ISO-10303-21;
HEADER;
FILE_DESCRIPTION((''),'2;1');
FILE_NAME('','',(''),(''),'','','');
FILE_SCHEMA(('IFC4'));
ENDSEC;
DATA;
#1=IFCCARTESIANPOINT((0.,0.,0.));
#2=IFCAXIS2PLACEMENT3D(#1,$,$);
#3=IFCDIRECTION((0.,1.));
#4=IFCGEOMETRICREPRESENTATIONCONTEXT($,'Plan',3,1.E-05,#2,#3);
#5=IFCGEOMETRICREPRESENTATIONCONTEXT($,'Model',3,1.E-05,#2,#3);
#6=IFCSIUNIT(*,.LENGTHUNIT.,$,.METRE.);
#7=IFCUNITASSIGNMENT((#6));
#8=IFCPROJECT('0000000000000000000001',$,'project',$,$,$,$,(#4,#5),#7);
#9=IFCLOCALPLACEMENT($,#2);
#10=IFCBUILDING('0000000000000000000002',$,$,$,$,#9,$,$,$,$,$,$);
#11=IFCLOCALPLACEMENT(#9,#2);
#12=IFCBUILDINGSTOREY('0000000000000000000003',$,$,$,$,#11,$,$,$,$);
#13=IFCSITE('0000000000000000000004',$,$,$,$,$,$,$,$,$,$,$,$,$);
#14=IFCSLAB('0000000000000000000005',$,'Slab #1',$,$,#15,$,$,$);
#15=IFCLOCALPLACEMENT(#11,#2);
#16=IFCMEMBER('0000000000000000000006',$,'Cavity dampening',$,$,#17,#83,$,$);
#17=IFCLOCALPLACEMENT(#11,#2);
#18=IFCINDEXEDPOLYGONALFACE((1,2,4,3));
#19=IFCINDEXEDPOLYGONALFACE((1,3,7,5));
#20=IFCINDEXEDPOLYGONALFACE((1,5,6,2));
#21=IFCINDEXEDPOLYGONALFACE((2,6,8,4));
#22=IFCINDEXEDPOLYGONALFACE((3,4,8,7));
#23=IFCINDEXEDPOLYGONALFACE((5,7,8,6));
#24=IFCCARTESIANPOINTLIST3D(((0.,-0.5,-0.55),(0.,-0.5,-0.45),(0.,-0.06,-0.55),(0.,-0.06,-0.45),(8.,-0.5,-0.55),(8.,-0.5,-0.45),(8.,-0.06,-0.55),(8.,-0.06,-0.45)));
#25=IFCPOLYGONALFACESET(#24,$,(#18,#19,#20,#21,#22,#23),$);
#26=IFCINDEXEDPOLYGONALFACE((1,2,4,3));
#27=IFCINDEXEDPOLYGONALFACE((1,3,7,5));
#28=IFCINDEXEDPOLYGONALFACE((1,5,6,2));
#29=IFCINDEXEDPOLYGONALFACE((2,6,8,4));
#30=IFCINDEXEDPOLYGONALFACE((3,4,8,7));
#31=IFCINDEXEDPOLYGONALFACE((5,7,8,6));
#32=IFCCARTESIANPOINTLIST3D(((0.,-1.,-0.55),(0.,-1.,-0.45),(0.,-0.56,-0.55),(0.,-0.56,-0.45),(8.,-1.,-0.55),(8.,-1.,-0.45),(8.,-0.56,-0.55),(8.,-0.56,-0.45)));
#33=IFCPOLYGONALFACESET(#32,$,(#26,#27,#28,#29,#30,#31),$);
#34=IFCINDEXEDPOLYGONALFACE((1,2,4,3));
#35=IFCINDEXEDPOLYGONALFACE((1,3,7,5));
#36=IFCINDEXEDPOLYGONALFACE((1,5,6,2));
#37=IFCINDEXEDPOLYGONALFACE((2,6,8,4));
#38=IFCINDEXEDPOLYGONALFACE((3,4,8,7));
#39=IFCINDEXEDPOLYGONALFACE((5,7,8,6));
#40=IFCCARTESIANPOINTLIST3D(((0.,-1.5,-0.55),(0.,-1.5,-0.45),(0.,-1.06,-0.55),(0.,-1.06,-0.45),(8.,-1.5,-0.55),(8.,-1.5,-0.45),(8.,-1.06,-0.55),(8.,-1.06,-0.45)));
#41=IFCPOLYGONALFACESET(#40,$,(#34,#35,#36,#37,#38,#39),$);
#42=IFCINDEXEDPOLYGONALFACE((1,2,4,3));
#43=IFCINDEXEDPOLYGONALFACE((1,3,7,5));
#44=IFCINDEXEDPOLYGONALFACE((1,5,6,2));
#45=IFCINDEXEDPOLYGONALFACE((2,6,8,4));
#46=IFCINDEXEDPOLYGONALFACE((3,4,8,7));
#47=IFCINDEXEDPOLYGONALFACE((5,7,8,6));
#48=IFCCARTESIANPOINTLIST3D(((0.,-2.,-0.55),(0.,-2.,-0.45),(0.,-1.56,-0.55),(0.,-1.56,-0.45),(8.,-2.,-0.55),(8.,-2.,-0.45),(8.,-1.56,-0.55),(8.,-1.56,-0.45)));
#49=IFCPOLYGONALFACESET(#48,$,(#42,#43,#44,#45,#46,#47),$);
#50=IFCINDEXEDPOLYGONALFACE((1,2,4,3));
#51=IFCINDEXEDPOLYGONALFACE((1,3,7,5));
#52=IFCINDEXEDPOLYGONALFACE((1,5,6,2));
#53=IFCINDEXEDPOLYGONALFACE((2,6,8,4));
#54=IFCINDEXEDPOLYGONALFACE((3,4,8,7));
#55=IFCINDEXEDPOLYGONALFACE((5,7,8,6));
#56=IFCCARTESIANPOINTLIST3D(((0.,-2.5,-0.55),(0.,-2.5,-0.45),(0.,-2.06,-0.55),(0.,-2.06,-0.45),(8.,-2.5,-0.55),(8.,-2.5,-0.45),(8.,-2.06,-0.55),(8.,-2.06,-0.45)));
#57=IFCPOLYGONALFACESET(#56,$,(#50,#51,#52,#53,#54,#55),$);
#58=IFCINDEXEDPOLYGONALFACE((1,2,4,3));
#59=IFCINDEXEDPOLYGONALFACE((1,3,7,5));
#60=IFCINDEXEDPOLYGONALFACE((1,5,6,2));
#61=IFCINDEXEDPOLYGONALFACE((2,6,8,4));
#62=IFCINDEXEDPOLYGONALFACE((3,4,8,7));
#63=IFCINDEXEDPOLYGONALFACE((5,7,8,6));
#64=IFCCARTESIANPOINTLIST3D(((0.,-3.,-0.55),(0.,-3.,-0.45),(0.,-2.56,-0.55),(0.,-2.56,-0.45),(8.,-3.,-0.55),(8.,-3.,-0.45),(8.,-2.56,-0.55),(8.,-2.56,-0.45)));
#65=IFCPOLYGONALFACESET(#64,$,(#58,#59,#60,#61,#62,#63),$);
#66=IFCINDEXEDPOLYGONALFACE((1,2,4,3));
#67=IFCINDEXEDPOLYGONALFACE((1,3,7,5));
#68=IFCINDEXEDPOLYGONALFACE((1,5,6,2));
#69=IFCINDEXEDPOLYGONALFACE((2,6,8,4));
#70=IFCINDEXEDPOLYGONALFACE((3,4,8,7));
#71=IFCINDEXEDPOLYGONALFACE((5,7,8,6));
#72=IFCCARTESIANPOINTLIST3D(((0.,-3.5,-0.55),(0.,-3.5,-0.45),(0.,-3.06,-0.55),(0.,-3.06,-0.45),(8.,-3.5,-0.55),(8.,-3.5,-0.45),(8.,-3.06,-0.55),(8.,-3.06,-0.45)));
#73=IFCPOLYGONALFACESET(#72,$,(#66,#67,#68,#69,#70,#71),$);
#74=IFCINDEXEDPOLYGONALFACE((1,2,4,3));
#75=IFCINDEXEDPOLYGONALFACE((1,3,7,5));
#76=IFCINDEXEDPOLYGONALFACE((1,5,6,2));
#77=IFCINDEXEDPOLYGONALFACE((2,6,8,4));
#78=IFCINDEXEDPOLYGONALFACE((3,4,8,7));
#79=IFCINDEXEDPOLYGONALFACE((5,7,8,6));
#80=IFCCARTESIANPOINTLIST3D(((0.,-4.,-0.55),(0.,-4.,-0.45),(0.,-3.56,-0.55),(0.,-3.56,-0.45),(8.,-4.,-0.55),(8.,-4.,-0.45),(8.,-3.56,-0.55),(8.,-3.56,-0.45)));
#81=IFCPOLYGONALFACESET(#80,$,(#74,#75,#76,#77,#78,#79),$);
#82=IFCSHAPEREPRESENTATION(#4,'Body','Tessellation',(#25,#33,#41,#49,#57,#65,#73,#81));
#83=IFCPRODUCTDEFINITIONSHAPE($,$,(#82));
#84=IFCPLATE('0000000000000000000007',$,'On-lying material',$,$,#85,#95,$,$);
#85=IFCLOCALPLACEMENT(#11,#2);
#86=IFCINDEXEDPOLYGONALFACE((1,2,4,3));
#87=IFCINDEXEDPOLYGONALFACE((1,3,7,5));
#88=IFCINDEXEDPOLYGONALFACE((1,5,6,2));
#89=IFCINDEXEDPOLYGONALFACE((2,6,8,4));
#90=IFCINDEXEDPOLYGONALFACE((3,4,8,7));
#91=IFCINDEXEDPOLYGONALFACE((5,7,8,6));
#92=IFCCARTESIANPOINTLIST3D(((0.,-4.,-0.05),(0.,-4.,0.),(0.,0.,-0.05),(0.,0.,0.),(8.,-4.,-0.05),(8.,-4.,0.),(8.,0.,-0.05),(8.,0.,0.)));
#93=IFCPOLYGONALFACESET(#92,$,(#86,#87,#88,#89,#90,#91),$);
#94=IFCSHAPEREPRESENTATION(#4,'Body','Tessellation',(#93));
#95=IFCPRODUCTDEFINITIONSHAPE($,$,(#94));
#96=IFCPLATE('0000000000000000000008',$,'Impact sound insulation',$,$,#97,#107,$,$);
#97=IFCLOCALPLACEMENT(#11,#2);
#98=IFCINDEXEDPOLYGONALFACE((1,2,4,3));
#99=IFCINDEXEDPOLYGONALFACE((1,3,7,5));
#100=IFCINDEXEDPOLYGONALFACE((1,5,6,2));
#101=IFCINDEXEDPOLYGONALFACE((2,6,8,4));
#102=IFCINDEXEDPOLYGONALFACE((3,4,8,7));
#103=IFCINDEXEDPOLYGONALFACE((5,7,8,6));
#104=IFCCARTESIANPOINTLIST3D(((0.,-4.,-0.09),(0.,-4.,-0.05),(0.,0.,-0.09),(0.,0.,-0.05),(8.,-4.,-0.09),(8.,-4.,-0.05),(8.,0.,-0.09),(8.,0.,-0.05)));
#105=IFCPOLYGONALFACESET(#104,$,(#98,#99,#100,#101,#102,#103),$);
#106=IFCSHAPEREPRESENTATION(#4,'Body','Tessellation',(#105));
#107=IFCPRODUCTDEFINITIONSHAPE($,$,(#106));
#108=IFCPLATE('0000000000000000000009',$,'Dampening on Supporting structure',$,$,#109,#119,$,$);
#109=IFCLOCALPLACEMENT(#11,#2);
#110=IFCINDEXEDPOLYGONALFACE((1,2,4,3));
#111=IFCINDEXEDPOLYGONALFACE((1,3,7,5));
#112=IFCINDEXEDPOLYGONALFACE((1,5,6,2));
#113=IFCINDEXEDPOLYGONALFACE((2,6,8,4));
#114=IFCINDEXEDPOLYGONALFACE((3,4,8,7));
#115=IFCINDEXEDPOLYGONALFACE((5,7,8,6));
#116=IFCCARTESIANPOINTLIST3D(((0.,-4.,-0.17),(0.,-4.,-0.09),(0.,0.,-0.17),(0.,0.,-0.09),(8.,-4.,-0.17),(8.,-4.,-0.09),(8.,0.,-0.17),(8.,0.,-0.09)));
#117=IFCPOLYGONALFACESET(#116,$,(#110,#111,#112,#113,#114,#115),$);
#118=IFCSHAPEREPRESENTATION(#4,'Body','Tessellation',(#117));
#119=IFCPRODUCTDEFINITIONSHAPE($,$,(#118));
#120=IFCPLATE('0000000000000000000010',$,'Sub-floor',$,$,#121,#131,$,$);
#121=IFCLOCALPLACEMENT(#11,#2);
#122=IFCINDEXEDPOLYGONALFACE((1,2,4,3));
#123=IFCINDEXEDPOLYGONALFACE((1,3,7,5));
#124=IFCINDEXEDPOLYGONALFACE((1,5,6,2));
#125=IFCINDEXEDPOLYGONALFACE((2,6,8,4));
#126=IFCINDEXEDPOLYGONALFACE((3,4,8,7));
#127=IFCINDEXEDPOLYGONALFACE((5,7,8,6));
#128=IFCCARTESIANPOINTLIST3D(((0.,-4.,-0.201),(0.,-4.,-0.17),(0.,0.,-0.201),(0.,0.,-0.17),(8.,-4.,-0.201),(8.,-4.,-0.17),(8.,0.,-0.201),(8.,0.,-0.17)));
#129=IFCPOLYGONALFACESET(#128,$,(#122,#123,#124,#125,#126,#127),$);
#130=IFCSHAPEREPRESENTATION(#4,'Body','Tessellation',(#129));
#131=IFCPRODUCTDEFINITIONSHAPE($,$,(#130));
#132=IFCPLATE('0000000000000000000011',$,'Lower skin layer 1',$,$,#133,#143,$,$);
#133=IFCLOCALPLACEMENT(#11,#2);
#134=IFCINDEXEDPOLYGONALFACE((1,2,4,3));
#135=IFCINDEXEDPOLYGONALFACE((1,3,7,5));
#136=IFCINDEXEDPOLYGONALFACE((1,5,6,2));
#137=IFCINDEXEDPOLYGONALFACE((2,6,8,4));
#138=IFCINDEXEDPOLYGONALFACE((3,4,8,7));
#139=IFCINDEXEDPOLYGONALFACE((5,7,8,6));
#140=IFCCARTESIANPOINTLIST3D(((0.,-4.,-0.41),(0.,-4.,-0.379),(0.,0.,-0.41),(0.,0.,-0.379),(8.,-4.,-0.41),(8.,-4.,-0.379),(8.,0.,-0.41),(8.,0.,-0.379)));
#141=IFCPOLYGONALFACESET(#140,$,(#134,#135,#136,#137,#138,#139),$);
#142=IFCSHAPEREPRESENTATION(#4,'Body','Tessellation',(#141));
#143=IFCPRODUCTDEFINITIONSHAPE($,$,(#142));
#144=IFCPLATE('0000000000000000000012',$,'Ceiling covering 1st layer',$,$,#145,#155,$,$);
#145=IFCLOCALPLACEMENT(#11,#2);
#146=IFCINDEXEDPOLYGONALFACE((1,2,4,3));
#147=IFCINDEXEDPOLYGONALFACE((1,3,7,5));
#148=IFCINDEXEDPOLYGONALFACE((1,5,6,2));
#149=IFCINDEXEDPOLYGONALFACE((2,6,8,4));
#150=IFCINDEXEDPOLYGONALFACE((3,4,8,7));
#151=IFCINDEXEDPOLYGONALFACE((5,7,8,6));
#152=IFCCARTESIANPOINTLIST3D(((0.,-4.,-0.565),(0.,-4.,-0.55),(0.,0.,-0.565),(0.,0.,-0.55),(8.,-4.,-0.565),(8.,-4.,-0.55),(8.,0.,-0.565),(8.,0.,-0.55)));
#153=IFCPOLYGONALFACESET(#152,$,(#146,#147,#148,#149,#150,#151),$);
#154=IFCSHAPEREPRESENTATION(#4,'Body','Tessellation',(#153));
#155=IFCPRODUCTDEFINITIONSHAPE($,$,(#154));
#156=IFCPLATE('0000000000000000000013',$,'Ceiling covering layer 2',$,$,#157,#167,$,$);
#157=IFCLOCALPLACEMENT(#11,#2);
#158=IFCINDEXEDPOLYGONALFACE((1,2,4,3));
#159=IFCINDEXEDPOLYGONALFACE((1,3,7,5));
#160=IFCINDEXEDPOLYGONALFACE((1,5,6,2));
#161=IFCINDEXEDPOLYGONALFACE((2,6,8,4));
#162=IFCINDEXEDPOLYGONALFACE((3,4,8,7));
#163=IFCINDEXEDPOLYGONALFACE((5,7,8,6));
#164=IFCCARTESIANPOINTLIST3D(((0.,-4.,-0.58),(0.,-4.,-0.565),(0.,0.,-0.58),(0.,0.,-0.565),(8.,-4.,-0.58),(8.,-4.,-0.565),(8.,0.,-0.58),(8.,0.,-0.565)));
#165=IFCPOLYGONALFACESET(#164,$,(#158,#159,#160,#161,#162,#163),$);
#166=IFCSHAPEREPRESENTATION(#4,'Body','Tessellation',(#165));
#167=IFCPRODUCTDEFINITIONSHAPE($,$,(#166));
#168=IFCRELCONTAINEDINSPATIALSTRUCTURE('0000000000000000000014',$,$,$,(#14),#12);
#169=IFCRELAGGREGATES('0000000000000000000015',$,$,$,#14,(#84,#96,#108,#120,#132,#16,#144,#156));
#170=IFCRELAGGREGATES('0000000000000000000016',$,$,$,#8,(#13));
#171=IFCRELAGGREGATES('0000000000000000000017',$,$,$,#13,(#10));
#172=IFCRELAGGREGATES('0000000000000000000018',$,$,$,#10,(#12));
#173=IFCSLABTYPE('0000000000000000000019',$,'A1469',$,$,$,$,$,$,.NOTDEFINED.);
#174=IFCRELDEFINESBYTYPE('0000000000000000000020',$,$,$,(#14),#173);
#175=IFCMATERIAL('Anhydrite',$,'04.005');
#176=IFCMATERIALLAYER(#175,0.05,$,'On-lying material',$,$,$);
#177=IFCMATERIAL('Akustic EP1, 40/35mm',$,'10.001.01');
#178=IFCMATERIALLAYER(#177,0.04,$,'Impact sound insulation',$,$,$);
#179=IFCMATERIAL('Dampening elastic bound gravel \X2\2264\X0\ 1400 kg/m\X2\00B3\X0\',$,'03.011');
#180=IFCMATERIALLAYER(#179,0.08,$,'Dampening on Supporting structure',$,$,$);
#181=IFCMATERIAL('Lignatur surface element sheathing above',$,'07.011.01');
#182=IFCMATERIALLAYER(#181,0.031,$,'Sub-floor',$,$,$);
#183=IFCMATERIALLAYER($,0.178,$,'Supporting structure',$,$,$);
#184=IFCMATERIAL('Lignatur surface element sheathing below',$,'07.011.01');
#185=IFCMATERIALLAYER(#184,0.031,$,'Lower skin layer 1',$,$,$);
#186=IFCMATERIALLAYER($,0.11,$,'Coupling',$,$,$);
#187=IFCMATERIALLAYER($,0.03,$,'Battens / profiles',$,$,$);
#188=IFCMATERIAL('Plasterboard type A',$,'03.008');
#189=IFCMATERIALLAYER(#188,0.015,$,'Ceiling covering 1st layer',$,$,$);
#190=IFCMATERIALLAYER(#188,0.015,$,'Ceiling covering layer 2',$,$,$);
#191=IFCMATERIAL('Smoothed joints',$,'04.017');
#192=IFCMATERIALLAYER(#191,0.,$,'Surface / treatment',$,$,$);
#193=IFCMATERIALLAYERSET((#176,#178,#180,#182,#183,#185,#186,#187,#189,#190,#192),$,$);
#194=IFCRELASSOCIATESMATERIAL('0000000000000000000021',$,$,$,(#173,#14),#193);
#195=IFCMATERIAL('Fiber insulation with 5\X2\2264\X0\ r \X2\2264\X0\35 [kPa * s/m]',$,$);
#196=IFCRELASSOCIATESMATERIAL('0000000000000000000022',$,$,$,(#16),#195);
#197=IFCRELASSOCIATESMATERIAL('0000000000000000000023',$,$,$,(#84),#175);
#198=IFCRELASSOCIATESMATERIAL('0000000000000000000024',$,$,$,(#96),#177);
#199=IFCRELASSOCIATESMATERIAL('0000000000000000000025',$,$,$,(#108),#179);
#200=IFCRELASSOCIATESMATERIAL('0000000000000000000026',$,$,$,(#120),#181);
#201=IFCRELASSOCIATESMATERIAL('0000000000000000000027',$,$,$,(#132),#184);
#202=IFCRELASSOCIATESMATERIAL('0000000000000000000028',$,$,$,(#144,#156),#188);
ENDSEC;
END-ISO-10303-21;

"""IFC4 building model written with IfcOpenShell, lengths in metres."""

from ifc_helpers import new_model, si_unit, direction, frame, frame_2d, origin, origin_with_axes, place, context, project, spatial, rectangle, extrude, material, layer, layer_set, type_object, element, aggregate, save


model = new_model("IFC4")

# Units and contexts
plan_context = context("Plan", 3, precision=1e-05, world=origin(), true_north=direction((0.0, 1.0)))
model_context = context("Model", 3, precision=1e-05, world=origin(), true_north=direction((0.0, 1.0)))
ifc_project = project(units=[si_unit("LENGTHUNIT", "METRE")], contexts=[plan_context, model_context])

# Site, building, storey
site = spatial("IfcSite", under=ifc_project)
building_placement = place(None, origin())
building = spatial("IfcBuilding", under=site, at=building_placement)
storey_placement = place(building_placement, origin())
storey = spatial("IfcBuildingStorey", under=building, at=storey_placement)

# Slab, member, plates
ifc_material_1 = material(Name="Anhydrite", Category="04.005")
ifc_layer_1 = layer(ifc_material_1, 0.05, Name="On-lying material")
ifc_material_2 = material(Name="Akustic EP1, 40/35mm", Category="10.001.01")
ifc_layer_2 = layer(ifc_material_2, 0.04, Name="Impact sound insulation")
ifc_material_3 = material(Name="Dampening elastic bound gravel ≤ 1400 kg/m³", Category="03.011")
ifc_layer_3 = layer(ifc_material_3, 0.08, Name="Dampening on Supporting structure")
ifc_material_4 = material(Name="Lignatur surface element sheathing above", Category="07.011.01")
ifc_layer_4 = layer(ifc_material_4, 0.031, Name="Sub-floor")
ifc_layer_5 = layer(None, 0.178, Name="Supporting structure")
ifc_material_5 = material(Name="Lignatur surface element sheathing below", Category="07.011.01")
ifc_layer_6 = layer(ifc_material_5, 0.031, Name="Lower skin layer 1")
ifc_layer_7 = layer(None, 0.11, Name="Coupling")
ifc_layer_8 = layer(None, 0.03, Name="Battens / profiles")
ifc_material_6 = material(Name="Plasterboard type A", Category="03.008")
ifc_layer_9 = layer(ifc_material_6, 0.015, Name="Ceiling covering 1st layer")
ifc_layer_10 = layer(ifc_material_6, 0.015, Name="Ceiling covering layer 2")
ifc_material_7 = material(Name="Smoothed joints", Category="04.017")
ifc_layer_11 = layer(ifc_material_7, 0.0, Name="Surface / treatment")
ifc_layer_set = layer_set([ifc_layer_1, ifc_layer_2, ifc_layer_3, ifc_layer_4, ifc_layer_5, ifc_layer_6, ifc_layer_7, ifc_layer_8, ifc_layer_9, ifc_layer_10, ifc_layer_11])
slab_type = type_object("IfcSlabType", Name="A1469", PredefinedType="NOTDEFINED", material=ifc_layer_set)
slab_placement = place(None, frame((0.0, 0.0, 0.0), z_axis=(0.0, 0.0, -1.0), x_axis=(1.0, 0.0, 0.0)))
slab = element("IfcSlab", 1, at=slab_placement, inside=storey, type_object=slab_type, material=ifc_layer_set, Name="Slab #1")
ifc_material_8 = material(Name="Fiber insulation with 5≤ r ≤35 [kPa * s/m]")
member_1_placement = place(slab_placement, origin())
member_1 = element("IfcMember", 2, at=member_1_placement, material=ifc_material_8, Name="Cavity dampening", context=plan_context, shape_type="SweptSolid", body=[
    extrude(rectangle(XDim=0.44, YDim=0.1, at=frame_2d((0.22, 0.05), x_axis=(1.0, 0.0))), frame((0.0, 0.06, 0.45), z_axis=(1.0, 0.0, 0.0), x_axis=(0.0, 1.0, 0.0)), (0.0, 0.0, 1.0), 8.0),
    extrude(rectangle(XDim=0.44, YDim=0.1, at=frame_2d((0.22, 0.05), x_axis=(1.0, 0.0))), frame((0.0, 0.56, 0.45), z_axis=(1.0, 0.0, 0.0), x_axis=(0.0, 1.0, 0.0)), (0.0, 0.0, 1.0), 8.0),
    extrude(rectangle(XDim=0.44, YDim=0.1, at=frame_2d((0.22, 0.05), x_axis=(1.0, 0.0))), frame((0.0, 1.06, 0.45), z_axis=(1.0, 0.0, 0.0), x_axis=(0.0, 1.0, 0.0)), (0.0, 0.0, 1.0), 8.0),
    extrude(rectangle(XDim=0.44, YDim=0.1, at=frame_2d((0.22, 0.05), x_axis=(1.0, 0.0))), frame((0.0, 1.56, 0.45), z_axis=(1.0, 0.0, 0.0), x_axis=(0.0, 1.0, 0.0)), (0.0, 0.0, 1.0), 8.0),
    extrude(rectangle(XDim=0.44, YDim=0.1, at=frame_2d((0.22, 0.05), x_axis=(1.0, 0.0))), frame((0.0, 2.06, 0.45), z_axis=(1.0, 0.0, 0.0), x_axis=(0.0, 1.0, 0.0)), (0.0, 0.0, 1.0), 8.0),
    extrude(rectangle(XDim=0.44, YDim=0.1, at=frame_2d((0.22, 0.05), x_axis=(1.0, 0.0))), frame((0.0, 2.56, 0.45), z_axis=(1.0, 0.0, 0.0), x_axis=(0.0, 1.0, 0.0)), (0.0, 0.0, 1.0), 8.0),
    extrude(rectangle(XDim=0.44, YDim=0.1, at=frame_2d((0.22, 0.05), x_axis=(1.0, 0.0))), frame((0.0, 3.06, 0.45), z_axis=(1.0, 0.0, 0.0), x_axis=(0.0, 1.0, 0.0)), (0.0, 0.0, 1.0), 8.0),
    extrude(rectangle(XDim=0.44, YDim=0.1, at=frame_2d((0.22, 0.05), x_axis=(1.0, 0.0))), frame((0.0, 3.56, 0.45), z_axis=(1.0, 0.0, 0.0), x_axis=(0.0, 1.0, 0.0)), (0.0, 0.0, 1.0), 8.0),
])
plate_1_placement = place(slab_placement, origin())
plate_1 = element("IfcPlate", 3, at=plate_1_placement, material=ifc_material_1, Name="On-lying material", context=plan_context, shape_type="SweptSolid", body=[
    extrude(rectangle(XDim=8.0, YDim=4.0, at=frame_2d((4.0, 2.0), x_axis=(1.0, 0.0))), origin_with_axes(), (0.0, 0.0, 1.0), 0.05),
])
plate_2_placement = place(slab_placement, origin())
plate_2 = element("IfcPlate", 4, at=plate_2_placement, material=ifc_material_2, Name="Impact sound insulation", context=plan_context, shape_type="SweptSolid", body=[
    extrude(rectangle(XDim=8.0, YDim=4.0, at=frame_2d((4.0, 2.0), x_axis=(1.0, 0.0))), frame((0.0, 0.0, 0.05), z_axis=(0.0, 0.0, 1.0), x_axis=(1.0, 0.0, 0.0)), (0.0, 0.0, 1.0), 0.04),
])
plate_3_placement = place(slab_placement, origin())
plate_3 = element("IfcPlate", 5, at=plate_3_placement, material=ifc_material_3, Name="Dampening on Supporting structure", context=plan_context, shape_type="SweptSolid", body=[
    extrude(rectangle(XDim=8.0, YDim=4.0, at=frame_2d((4.0, 2.0), x_axis=(1.0, 0.0))), frame((0.0, 0.0, 0.09), z_axis=(0.0, 0.0, 1.0), x_axis=(1.0, 0.0, 0.0)), (0.0, 0.0, 1.0), 0.08),
])
plate_4_placement = place(slab_placement, origin())
plate_4 = element("IfcPlate", 6, at=plate_4_placement, material=ifc_material_4, Name="Sub-floor", context=plan_context, shape_type="SweptSolid", body=[
    extrude(rectangle(XDim=8.0, YDim=4.0, at=frame_2d((4.0, 2.0), x_axis=(1.0, 0.0))), frame((0.0, 0.0, 0.17), z_axis=(0.0, 0.0, 1.0), x_axis=(1.0, 0.0, 0.0)), (0.0, 0.0, 1.0), 0.031),
])
plate_5_placement = place(slab_placement, origin())
plate_5 = element("IfcPlate", 7, at=plate_5_placement, material=ifc_material_5, Name="Lower skin layer 1", context=plan_context, shape_type="SweptSolid", body=[
    extrude(rectangle(XDim=8.0, YDim=4.0, at=frame_2d((4.0, 2.0), x_axis=(1.0, 0.0))), frame((0.0, 0.0, 0.379), z_axis=(0.0, 0.0, 1.0), x_axis=(1.0, 0.0, 0.0)), (0.0, 0.0, 1.0), 0.031),
])
plate_6_placement = place(slab_placement, origin())
plate_6 = element("IfcPlate", 8, at=plate_6_placement, material=ifc_material_6, Name="Ceiling covering 1st layer", context=plan_context, shape_type="SweptSolid", body=[
    extrude(rectangle(XDim=8.0, YDim=4.0, at=frame_2d((4.0, 2.0), x_axis=(1.0, 0.0))), frame((0.0, 0.0, 0.55), z_axis=(0.0, 0.0, 1.0), x_axis=(1.0, 0.0, 0.0)), (0.0, 0.0, 1.0), 0.015),
])
plate_7_placement = place(slab_placement, origin())
plate_7 = element("IfcPlate", 9, at=plate_7_placement, material=ifc_material_6, Name="Ceiling covering layer 2", context=plan_context, shape_type="SweptSolid", body=[
    extrude(rectangle(XDim=8.0, YDim=4.0, at=frame_2d((4.0, 2.0), x_axis=(1.0, 0.0))), frame((0.0, 0.0, 0.565), z_axis=(0.0, 0.0, 1.0), x_axis=(1.0, 0.0, 0.0)), (0.0, 0.0, 1.0), 0.015),
])
aggregate(slab, [plate_1, plate_2, plate_3, plate_4, plate_5, member_1, plate_6, plate_7])

save(model, "model.ifc")
